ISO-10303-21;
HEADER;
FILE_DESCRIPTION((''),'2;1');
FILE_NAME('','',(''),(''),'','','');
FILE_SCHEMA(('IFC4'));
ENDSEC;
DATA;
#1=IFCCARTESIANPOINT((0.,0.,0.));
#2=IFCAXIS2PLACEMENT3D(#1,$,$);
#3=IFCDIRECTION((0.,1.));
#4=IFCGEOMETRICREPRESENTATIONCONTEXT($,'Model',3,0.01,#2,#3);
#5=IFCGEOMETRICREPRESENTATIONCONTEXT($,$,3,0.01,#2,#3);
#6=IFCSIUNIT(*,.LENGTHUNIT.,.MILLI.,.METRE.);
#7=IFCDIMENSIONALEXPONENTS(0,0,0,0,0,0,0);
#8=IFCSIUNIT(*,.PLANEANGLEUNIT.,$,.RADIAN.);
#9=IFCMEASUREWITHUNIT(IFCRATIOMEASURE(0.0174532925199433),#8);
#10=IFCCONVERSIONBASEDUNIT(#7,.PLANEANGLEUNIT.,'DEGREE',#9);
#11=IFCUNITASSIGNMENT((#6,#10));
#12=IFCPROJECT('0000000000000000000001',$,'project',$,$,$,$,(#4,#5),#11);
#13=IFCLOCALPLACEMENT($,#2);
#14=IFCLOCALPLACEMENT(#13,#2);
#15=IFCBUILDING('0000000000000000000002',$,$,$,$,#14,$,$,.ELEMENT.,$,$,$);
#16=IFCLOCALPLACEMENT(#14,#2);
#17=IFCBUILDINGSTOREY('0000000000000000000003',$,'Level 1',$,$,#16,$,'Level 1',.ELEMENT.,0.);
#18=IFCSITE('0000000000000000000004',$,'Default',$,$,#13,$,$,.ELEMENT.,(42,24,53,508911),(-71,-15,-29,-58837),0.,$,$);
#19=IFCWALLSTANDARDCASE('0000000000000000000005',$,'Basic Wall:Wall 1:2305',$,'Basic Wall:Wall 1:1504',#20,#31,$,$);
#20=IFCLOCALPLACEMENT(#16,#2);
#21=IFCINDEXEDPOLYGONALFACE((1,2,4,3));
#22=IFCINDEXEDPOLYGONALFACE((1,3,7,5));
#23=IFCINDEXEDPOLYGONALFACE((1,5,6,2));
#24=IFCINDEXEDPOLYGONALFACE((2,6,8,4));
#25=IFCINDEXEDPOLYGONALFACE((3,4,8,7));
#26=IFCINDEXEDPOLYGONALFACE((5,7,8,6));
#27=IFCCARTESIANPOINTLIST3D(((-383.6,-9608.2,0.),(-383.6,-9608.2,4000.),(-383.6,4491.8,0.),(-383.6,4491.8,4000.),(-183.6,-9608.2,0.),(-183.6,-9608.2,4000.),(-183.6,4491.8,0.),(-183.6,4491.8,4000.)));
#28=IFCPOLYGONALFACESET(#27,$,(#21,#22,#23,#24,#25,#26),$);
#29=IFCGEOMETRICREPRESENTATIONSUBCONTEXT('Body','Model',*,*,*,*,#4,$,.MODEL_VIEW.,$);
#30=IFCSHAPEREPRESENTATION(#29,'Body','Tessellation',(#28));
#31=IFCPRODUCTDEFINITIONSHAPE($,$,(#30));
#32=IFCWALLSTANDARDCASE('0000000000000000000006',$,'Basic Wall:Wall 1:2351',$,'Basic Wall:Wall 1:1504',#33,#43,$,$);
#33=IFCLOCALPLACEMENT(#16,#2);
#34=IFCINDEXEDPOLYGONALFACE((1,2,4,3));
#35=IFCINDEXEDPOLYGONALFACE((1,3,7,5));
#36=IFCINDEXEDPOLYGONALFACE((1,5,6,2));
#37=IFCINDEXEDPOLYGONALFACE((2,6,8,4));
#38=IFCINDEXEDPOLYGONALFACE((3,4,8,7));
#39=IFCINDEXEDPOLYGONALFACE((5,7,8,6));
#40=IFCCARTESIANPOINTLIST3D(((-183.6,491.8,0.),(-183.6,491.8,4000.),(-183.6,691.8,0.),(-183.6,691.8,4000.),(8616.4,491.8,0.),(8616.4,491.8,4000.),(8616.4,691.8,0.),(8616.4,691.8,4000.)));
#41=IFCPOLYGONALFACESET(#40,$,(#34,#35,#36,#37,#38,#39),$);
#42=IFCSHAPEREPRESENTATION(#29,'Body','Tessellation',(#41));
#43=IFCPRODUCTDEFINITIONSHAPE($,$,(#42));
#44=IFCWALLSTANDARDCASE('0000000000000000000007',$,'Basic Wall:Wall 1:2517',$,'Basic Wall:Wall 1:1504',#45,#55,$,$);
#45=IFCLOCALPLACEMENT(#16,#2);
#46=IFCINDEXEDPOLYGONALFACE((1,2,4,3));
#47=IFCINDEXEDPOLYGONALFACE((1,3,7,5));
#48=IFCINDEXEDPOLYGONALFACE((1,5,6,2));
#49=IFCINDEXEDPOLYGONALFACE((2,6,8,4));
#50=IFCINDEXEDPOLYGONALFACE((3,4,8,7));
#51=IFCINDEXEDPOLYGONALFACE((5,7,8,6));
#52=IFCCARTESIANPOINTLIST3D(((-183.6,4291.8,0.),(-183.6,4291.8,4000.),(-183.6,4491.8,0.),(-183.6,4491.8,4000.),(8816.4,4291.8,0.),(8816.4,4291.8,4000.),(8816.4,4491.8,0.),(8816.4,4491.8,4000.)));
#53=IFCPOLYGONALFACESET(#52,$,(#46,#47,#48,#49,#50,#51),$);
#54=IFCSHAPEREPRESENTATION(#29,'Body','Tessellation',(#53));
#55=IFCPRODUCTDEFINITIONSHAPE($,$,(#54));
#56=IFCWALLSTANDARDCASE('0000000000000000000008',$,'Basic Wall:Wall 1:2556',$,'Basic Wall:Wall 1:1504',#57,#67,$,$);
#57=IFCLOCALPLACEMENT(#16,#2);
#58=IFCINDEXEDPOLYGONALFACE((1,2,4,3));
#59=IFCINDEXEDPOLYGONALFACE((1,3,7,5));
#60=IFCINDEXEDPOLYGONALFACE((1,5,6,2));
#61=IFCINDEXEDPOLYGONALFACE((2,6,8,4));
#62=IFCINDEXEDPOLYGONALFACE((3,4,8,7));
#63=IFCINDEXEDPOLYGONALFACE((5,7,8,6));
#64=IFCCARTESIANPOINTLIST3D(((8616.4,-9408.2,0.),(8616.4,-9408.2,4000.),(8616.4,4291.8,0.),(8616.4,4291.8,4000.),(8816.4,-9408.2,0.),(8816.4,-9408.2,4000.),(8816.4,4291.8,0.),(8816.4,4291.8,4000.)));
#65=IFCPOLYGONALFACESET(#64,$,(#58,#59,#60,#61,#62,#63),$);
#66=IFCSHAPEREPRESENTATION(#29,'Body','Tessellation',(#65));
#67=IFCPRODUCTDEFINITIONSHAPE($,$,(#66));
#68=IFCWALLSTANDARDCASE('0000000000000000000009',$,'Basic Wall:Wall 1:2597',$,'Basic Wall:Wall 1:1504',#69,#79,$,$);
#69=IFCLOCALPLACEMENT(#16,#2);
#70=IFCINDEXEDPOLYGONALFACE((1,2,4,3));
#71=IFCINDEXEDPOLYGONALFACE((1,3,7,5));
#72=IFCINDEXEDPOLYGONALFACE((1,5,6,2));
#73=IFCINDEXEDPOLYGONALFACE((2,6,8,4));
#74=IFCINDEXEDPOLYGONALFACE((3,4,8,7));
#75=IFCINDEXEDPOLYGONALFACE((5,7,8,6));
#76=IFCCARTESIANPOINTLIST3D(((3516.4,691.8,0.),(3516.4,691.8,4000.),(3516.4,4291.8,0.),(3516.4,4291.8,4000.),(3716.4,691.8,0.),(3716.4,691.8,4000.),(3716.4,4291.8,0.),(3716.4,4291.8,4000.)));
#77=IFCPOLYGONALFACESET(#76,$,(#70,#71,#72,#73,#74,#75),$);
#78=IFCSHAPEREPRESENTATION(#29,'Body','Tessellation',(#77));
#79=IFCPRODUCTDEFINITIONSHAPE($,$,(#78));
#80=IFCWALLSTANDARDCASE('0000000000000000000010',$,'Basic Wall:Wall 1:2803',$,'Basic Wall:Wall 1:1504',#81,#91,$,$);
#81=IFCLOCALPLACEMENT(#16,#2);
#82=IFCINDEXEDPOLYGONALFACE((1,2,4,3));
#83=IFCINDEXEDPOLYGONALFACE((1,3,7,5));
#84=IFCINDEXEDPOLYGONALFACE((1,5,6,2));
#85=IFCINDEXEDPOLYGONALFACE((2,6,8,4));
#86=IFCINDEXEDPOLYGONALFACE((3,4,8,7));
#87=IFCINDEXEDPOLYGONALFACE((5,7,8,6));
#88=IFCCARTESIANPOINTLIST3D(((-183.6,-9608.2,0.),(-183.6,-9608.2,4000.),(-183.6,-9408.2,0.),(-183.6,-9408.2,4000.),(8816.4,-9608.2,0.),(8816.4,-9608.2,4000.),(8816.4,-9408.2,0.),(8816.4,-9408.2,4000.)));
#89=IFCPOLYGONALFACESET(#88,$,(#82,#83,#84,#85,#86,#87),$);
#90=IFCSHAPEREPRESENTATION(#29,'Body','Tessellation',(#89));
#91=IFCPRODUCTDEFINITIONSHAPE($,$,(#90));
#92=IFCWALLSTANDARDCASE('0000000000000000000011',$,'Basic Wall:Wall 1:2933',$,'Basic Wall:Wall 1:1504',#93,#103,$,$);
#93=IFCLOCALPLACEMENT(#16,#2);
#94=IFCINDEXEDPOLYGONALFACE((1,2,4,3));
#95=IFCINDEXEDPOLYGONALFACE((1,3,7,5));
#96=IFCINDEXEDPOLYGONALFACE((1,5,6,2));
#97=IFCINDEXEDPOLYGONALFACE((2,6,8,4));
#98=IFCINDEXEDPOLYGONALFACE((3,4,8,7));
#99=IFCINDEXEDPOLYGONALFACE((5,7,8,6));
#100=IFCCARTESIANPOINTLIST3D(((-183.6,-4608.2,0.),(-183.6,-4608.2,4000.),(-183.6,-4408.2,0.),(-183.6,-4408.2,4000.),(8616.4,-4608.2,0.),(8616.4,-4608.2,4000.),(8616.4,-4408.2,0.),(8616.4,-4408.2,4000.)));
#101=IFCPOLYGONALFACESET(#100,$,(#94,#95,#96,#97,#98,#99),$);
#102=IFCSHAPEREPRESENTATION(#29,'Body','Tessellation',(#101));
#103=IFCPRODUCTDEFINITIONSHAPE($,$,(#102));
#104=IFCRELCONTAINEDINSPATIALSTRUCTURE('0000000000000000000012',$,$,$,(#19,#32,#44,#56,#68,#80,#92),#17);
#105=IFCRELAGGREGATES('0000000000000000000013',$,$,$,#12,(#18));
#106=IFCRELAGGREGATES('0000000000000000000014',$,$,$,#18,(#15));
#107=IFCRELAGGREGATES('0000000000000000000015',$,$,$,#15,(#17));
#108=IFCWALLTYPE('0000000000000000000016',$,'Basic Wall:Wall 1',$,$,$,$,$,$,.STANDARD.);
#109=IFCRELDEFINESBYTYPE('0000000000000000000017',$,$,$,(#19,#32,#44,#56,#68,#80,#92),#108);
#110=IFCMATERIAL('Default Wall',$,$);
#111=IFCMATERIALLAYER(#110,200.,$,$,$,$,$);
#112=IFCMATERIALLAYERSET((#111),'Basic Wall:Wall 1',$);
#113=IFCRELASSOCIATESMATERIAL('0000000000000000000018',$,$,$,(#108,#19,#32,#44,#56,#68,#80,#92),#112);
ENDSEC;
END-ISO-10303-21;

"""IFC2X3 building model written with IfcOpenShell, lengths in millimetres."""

from ifc_helpers import new_model, entity, si_unit, converted_unit, direction, frame, frame_2d, origin, place, context, subcontext, project, spatial, rectangle, extrude, material, layer, layer_set, layer_usage, type_object, element, save


model = new_model("IFC2X3")

# Units and contexts
model_context = context("Model", 3, precision=0.01, world=origin(), true_north=direction((0.0, 1.0)))
context_of_model = context(None, 3, precision=0.01, world=origin(), true_north=direction((0.0, 1.0)))
body_context = subcontext(model_context, "Body", "Model", "MODEL_VIEW")
ifc_project = project(units=[si_unit("LENGTHUNIT", "METRE", prefix="MILLI"), converted_unit("PLANEANGLEUNIT", "DEGREE", entity("IfcRatioMeasure", 0.0174532925199433), si_unit("PLANEANGLEUNIT", "RADIAN"), dimensions=[0, 0, 0, 0, 0, 0, 0])], contexts=[model_context, context_of_model])

# Site, building, storey
site_placement = place(None, origin())
site = spatial("IfcSite", under=ifc_project, at=site_placement, Name="Default", CompositionType="ELEMENT", RefLatitude=(42, 24, 53, 508911), RefLongitude=(-71, -15, -29, -58837), RefElevation=0.0)
building_placement = place(site_placement, origin())
building = spatial("IfcBuilding", under=site, at=building_placement, CompositionType="ELEMENT")
storey_placement = place(building_placement, origin())
storey = spatial("IfcBuildingStorey", under=building, at=storey_placement, Name="Level 1", LongName="Level 1", CompositionType="ELEMENT", Elevation=0.0)

# Walls
ifc_material_1 = material(Name="Default Wall")
ifc_layer = layer(ifc_material_1, 200.0)
ifc_layer_set = layer_set([ifc_layer], Name="Basic Wall:Wall 1")
ifc_layer_usage_1 = layer_usage(ifc_layer_set, "AXIS2", "NEGATIVE", 100.0)
wall_type = type_object("IfcWallType", Name="Basic Wall:Wall 1", PredefinedType="STANDARD", material=ifc_layer_set)
wall_1_placement = place(storey_placement, frame((-283.6, 4491.8, 0.0), z_axis=(0.0, 0.0, 1.0), x_axis=(0.0, -1.0, 0.0)))
element("IfcWallStandardCase", 1, at=wall_1_placement, inside=storey, type_object=wall_type, material=ifc_layer_usage_1, Name="Basic Wall:Wall 1:2305", ObjectType="Basic Wall:Wall 1:1504", context=body_context, shape_type="SweptSolid", body=[
    extrude(rectangle(XDim=14100.0, YDim=200.0, at=frame_2d((7050.0, 0.0), x_axis=(-1.0, 0.0))), origin(), (0.0, 0.0, 1.0), 4000.0),
])
ifc_layer_usage_2 = layer_usage(ifc_layer_set, "AXIS2", "NEGATIVE", 100.0)
wall_2_placement = place(storey_placement, frame((-183.6, 591.8, 0.0)))
element("IfcWallStandardCase", 2, at=wall_2_placement, inside=storey, type_object=wall_type, material=ifc_layer_usage_2, Name="Basic Wall:Wall 1:2351", ObjectType="Basic Wall:Wall 1:1504", context=body_context, shape_type="SweptSolid", body=[
    extrude(rectangle(XDim=8800.0, YDim=200.0, at=frame_2d((4400.0, 0.0), x_axis=(-1.0, 0.0))), origin(), (0.0, 0.0, 1.0), 4000.0),
])
ifc_layer_usage_3 = layer_usage(ifc_layer_set, "AXIS2", "NEGATIVE", 100.0)
wall_3_placement = place(storey_placement, frame((-183.6, 4391.8, 0.0)))
element("IfcWallStandardCase", 3, at=wall_3_placement, inside=storey, type_object=wall_type, material=ifc_layer_usage_3, Name="Basic Wall:Wall 1:2517", ObjectType="Basic Wall:Wall 1:1504", context=body_context, shape_type="SweptSolid", body=[
    extrude(rectangle(XDim=9000.0, YDim=200.0, at=frame_2d((4500.0, 0.0), x_axis=(-1.0, 0.0))), origin(), (0.0, 0.0, 1.0), 4000.0),
])
ifc_layer_usage_4 = layer_usage(ifc_layer_set, "AXIS2", "NEGATIVE", 100.0)
wall_4_placement = place(storey_placement, frame((8716.4, 4291.8, 0.0), z_axis=(0.0, 0.0, 1.0), x_axis=(0.0, -1.0, 0.0)))
element("IfcWallStandardCase", 4, at=wall_4_placement, inside=storey, type_object=wall_type, material=ifc_layer_usage_4, Name="Basic Wall:Wall 1:2556", ObjectType="Basic Wall:Wall 1:1504", context=body_context, shape_type="SweptSolid", body=[
    extrude(rectangle(XDim=13700.0, YDim=200.0, at=frame_2d((6850.0, 0.0), x_axis=(-1.0, 0.0))), origin(), (0.0, 0.0, 1.0), 4000.0),
])
ifc_layer_usage_5 = layer_usage(ifc_layer_set, "AXIS2", "NEGATIVE", 100.0)
wall_5_placement = place(storey_placement, frame((3616.4, 691.8, 0.0), z_axis=(0.0, 0.0, 1.0), x_axis=(0.0, 1.0, 0.0)))
element("IfcWallStandardCase", 5, at=wall_5_placement, inside=storey, type_object=wall_type, material=ifc_layer_usage_5, Name="Basic Wall:Wall 1:2597", ObjectType="Basic Wall:Wall 1:1504", context=body_context, shape_type="SweptSolid", body=[
    extrude(rectangle(XDim=3600.0, YDim=200.0, at=frame_2d((1800.0, 0.0), x_axis=(-1.0, 0.0))), origin(), (0.0, 0.0, 1.0), 4000.0),
])
ifc_layer_usage_6 = layer_usage(ifc_layer_set, "AXIS2", "NEGATIVE", 100.0)
wall_6_placement = place(storey_placement, frame((-183.6, -9508.2, 0.0)))
element("IfcWallStandardCase", 6, at=wall_6_placement, inside=storey, type_object=wall_type, material=ifc_layer_usage_6, Name="Basic Wall:Wall 1:2803", ObjectType="Basic Wall:Wall 1:1504", context=body_context, shape_type="SweptSolid", body=[
    extrude(rectangle(XDim=9000.0, YDim=200.0, at=frame_2d((4500.0, 0.0), x_axis=(-1.0, 0.0))), origin(), (0.0, 0.0, 1.0), 4000.0),
])
ifc_layer_usage_7 = layer_usage(ifc_layer_set, "AXIS2", "NEGATIVE", 100.0)
wall_7_placement = place(storey_placement, frame((8616.4, -4508.2, 0.0), z_axis=(0.0, 0.0, 1.0), x_axis=(-1.0, 0.0, 0.0)))
element("IfcWallStandardCase", 7, at=wall_7_placement, inside=storey, type_object=wall_type, material=ifc_layer_usage_7, Name="Basic Wall:Wall 1:2933", ObjectType="Basic Wall:Wall 1:1504", context=body_context, shape_type="SweptSolid", body=[
    extrude(rectangle(XDim=8800.0, YDim=200.0, at=frame_2d((4400.0, 0.0), x_axis=(-1.0, 0.0))), origin(), (0.0, 0.0, 1.0), 4000.0),
])

save(model, "model.ifc")
